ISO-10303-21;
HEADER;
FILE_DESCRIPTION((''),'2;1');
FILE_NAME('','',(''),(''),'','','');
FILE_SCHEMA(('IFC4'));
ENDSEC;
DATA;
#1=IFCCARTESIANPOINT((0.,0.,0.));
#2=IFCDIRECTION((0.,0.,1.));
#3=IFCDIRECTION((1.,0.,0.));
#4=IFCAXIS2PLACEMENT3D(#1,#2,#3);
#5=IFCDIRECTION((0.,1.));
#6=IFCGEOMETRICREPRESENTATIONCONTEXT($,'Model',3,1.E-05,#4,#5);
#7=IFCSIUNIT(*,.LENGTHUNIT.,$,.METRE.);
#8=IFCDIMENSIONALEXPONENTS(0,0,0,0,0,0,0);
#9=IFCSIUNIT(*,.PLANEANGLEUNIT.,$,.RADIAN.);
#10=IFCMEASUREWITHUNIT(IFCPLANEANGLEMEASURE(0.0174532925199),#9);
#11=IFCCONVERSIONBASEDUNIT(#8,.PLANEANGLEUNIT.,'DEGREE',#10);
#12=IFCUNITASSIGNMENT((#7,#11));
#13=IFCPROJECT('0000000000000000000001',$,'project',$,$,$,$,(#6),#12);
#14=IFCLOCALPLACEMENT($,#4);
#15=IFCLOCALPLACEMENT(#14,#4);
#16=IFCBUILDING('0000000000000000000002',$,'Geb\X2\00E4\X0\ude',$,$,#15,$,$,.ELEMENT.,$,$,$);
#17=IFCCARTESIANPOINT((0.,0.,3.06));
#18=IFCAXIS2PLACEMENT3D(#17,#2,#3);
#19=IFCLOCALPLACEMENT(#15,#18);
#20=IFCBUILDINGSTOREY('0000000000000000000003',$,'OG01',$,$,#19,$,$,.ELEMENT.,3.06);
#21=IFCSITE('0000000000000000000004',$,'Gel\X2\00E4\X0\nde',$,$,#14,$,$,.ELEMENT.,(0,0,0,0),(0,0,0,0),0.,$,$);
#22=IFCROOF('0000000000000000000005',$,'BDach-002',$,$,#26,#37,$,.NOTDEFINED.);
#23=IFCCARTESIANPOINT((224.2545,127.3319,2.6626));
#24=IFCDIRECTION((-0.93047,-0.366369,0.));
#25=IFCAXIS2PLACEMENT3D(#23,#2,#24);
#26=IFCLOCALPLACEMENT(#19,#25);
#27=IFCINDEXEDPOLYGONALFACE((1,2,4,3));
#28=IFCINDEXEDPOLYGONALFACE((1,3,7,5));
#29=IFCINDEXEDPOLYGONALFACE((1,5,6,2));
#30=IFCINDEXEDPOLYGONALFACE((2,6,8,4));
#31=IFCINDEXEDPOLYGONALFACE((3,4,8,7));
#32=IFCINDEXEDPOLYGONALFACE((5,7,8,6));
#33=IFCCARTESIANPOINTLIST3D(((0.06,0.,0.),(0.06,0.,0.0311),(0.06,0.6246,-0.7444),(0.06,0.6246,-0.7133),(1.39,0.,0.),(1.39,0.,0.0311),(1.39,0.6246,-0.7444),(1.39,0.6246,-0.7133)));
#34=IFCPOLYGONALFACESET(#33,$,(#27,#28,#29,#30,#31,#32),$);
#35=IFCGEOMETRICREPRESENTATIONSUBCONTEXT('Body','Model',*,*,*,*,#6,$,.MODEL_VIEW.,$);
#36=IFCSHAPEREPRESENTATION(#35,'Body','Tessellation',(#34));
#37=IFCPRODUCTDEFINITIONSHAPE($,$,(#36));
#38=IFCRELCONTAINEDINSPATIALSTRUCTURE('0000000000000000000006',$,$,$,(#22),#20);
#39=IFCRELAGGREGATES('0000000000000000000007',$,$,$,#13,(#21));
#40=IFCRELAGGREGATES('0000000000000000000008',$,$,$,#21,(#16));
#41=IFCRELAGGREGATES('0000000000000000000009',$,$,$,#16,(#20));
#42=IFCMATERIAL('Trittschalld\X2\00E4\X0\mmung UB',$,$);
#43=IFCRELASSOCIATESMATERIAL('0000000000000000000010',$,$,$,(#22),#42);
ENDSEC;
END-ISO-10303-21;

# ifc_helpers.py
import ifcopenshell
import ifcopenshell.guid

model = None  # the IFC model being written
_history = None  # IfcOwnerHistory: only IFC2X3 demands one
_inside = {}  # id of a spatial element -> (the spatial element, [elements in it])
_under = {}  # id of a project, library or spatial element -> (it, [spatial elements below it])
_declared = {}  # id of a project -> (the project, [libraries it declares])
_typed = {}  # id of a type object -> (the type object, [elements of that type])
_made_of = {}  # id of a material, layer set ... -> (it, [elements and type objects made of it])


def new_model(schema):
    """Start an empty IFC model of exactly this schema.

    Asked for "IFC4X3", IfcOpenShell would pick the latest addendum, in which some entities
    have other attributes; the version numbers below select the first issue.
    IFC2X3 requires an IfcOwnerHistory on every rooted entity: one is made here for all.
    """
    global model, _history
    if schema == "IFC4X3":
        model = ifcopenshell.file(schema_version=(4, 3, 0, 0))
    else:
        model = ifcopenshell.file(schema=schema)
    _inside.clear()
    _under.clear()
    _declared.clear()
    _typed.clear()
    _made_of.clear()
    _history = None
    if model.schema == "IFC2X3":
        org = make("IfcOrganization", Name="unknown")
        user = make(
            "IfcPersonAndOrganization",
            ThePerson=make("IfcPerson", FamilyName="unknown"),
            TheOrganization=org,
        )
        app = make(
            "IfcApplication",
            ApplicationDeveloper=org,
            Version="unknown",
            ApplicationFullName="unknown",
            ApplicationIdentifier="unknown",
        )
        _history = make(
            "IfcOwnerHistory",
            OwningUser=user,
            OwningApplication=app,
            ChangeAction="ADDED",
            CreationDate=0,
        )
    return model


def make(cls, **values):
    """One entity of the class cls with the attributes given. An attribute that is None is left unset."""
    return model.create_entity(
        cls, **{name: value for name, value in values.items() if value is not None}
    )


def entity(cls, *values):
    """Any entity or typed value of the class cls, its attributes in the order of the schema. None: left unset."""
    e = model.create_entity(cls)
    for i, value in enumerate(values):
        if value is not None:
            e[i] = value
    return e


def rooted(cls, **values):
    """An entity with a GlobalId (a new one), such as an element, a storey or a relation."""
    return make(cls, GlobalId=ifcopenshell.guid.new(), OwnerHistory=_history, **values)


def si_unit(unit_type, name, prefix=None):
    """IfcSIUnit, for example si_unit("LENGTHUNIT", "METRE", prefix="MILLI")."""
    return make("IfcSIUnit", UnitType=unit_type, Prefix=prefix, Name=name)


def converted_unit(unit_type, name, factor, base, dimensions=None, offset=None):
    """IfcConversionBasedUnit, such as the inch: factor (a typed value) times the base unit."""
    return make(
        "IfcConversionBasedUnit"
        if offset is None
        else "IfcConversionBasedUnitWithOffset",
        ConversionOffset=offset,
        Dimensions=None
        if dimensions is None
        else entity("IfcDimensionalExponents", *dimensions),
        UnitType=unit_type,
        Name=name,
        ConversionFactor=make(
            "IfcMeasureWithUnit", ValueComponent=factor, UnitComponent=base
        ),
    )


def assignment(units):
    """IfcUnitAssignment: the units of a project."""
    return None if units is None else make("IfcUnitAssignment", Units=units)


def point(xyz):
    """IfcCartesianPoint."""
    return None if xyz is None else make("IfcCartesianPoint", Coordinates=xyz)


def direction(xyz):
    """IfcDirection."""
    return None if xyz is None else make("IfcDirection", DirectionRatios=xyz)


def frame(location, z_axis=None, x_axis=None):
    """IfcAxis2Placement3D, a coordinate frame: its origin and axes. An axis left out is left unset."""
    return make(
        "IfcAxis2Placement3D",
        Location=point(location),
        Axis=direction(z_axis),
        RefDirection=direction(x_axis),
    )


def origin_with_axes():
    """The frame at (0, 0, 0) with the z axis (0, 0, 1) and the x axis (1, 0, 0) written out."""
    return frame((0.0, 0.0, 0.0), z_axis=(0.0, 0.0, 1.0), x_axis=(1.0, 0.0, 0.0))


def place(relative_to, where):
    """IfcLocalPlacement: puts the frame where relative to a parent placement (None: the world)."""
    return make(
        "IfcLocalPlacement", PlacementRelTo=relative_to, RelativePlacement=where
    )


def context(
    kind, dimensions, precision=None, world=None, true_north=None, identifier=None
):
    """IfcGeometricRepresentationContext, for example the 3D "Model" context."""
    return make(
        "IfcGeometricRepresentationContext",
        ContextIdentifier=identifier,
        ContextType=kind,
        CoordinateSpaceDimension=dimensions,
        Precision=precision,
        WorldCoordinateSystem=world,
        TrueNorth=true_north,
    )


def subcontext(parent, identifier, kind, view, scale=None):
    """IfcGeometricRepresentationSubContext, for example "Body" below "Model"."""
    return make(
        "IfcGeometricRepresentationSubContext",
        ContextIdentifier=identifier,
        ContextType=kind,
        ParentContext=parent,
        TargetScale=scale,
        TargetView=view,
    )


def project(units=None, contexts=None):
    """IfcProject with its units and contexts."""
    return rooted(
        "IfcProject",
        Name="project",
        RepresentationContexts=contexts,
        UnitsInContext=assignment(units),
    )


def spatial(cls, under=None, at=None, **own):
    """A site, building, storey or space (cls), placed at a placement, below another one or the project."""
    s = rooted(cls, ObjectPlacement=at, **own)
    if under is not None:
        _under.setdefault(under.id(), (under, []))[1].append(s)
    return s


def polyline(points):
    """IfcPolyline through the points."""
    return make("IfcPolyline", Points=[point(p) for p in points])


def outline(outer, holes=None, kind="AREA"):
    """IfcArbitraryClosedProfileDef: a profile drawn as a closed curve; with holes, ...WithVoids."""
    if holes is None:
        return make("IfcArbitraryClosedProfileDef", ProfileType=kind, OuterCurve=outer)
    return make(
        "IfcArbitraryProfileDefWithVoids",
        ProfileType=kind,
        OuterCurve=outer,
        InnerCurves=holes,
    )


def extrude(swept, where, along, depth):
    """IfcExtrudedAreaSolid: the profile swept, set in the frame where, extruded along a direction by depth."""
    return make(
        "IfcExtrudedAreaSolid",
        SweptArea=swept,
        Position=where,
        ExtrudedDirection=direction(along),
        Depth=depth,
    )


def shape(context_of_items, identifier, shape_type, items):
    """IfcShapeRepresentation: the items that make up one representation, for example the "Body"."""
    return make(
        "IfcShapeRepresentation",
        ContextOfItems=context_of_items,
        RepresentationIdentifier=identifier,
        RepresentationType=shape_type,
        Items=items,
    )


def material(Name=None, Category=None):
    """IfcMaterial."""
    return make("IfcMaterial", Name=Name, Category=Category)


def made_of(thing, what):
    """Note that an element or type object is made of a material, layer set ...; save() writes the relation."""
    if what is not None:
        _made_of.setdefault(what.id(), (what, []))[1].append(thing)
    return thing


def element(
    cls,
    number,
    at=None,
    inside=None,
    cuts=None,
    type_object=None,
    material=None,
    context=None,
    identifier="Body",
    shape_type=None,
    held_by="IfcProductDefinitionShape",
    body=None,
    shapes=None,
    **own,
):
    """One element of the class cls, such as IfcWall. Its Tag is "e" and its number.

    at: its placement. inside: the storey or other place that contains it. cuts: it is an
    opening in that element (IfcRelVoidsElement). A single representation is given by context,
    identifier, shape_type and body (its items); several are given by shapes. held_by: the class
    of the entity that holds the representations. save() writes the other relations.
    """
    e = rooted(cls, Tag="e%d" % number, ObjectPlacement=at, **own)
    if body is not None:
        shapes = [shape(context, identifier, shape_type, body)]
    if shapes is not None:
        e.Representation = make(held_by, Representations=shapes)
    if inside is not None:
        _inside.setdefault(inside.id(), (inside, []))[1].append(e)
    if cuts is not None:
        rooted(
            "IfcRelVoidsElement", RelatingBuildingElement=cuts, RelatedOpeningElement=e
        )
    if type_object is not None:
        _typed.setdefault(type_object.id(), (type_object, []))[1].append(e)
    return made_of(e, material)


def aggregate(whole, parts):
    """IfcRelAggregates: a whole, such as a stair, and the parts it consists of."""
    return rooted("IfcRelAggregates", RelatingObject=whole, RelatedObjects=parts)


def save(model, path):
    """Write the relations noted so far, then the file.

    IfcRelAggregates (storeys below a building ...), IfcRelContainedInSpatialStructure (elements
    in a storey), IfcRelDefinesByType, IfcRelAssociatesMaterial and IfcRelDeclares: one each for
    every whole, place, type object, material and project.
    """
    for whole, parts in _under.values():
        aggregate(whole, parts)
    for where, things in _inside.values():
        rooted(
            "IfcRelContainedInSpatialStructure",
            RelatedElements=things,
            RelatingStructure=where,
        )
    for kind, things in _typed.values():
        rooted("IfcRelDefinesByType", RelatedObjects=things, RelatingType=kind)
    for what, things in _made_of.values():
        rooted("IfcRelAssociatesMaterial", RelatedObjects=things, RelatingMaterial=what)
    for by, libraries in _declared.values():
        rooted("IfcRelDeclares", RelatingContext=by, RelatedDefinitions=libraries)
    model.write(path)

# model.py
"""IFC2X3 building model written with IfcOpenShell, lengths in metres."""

from ifc_helpers import new_model, entity, si_unit, converted_unit, direction, frame, origin_with_axes, place, context, subcontext, project, spatial, polyline, outline, extrude, material, element, save


model = new_model("IFC2X3")

# Units and contexts
model_context = context("Model", 3, precision=1e-05, world=origin_with_axes(), true_north=direction((0.0, 1.0)))
body_context = subcontext(model_context, "Body", "Model", "MODEL_VIEW")
ifc_project = project(units=[si_unit("LENGTHUNIT", "METRE"), converted_unit("PLANEANGLEUNIT", "DEGREE", entity("IfcPlaneAngleMeasure", 0.0174532925199), si_unit("PLANEANGLEUNIT", "RADIAN"), dimensions=[0, 0, 0, 0, 0, 0, 0])], contexts=[model_context])

# Site, building, storey
site_placement = place(None, origin_with_axes())
site = spatial("IfcSite", under=ifc_project, at=site_placement, Name="Gelände", CompositionType="ELEMENT", RefLatitude=(0, 0, 0, 0), RefLongitude=(0, 0, 0, 0), RefElevation=0.0)
building_placement = place(site_placement, origin_with_axes())
building = spatial("IfcBuilding", under=site, at=building_placement, Name="Gebäude", CompositionType="ELEMENT")
storey_placement = place(building_placement, frame((0.0, 0.0, 3.06), z_axis=(0.0, 0.0, 1.0), x_axis=(1.0, 0.0, 0.0)))
storey = spatial("IfcBuildingStorey", under=building, at=storey_placement, Name="OG01", CompositionType="ELEMENT", Elevation=3.06)

# Shared definitions
ifc_material_1 = material(Name="Trittschalldämmung UB")

# Roof
roof_1_placement = place(storey_placement, frame((224.2545, 127.3319, 2.6626), z_axis=(0.0, 0.0, 1.0), x_axis=(-0.93047, -0.366369, 0.0)))
element("IfcRoof", 1, at=roof_1_placement, inside=storey, material=ifc_material_1, Name="BDach-002", ShapeType="NOTDEFINED", context=body_context, shape_type="SweptSolid", body=[
    extrude(outline(polyline([(1.39, 0.0), (1.39, 0.9717), (0.06, 0.9717), (0.06, 0.0), (1.39, 0.0)])), frame((0.0, 0.0, 0.0), z_axis=(0.0, 0.766044, 0.642788), x_axis=(1.0, 0.0, 0.0)), (0.0, -0.766044, 0.642788), 0.0311),
])

save(model, "model.ifc")
